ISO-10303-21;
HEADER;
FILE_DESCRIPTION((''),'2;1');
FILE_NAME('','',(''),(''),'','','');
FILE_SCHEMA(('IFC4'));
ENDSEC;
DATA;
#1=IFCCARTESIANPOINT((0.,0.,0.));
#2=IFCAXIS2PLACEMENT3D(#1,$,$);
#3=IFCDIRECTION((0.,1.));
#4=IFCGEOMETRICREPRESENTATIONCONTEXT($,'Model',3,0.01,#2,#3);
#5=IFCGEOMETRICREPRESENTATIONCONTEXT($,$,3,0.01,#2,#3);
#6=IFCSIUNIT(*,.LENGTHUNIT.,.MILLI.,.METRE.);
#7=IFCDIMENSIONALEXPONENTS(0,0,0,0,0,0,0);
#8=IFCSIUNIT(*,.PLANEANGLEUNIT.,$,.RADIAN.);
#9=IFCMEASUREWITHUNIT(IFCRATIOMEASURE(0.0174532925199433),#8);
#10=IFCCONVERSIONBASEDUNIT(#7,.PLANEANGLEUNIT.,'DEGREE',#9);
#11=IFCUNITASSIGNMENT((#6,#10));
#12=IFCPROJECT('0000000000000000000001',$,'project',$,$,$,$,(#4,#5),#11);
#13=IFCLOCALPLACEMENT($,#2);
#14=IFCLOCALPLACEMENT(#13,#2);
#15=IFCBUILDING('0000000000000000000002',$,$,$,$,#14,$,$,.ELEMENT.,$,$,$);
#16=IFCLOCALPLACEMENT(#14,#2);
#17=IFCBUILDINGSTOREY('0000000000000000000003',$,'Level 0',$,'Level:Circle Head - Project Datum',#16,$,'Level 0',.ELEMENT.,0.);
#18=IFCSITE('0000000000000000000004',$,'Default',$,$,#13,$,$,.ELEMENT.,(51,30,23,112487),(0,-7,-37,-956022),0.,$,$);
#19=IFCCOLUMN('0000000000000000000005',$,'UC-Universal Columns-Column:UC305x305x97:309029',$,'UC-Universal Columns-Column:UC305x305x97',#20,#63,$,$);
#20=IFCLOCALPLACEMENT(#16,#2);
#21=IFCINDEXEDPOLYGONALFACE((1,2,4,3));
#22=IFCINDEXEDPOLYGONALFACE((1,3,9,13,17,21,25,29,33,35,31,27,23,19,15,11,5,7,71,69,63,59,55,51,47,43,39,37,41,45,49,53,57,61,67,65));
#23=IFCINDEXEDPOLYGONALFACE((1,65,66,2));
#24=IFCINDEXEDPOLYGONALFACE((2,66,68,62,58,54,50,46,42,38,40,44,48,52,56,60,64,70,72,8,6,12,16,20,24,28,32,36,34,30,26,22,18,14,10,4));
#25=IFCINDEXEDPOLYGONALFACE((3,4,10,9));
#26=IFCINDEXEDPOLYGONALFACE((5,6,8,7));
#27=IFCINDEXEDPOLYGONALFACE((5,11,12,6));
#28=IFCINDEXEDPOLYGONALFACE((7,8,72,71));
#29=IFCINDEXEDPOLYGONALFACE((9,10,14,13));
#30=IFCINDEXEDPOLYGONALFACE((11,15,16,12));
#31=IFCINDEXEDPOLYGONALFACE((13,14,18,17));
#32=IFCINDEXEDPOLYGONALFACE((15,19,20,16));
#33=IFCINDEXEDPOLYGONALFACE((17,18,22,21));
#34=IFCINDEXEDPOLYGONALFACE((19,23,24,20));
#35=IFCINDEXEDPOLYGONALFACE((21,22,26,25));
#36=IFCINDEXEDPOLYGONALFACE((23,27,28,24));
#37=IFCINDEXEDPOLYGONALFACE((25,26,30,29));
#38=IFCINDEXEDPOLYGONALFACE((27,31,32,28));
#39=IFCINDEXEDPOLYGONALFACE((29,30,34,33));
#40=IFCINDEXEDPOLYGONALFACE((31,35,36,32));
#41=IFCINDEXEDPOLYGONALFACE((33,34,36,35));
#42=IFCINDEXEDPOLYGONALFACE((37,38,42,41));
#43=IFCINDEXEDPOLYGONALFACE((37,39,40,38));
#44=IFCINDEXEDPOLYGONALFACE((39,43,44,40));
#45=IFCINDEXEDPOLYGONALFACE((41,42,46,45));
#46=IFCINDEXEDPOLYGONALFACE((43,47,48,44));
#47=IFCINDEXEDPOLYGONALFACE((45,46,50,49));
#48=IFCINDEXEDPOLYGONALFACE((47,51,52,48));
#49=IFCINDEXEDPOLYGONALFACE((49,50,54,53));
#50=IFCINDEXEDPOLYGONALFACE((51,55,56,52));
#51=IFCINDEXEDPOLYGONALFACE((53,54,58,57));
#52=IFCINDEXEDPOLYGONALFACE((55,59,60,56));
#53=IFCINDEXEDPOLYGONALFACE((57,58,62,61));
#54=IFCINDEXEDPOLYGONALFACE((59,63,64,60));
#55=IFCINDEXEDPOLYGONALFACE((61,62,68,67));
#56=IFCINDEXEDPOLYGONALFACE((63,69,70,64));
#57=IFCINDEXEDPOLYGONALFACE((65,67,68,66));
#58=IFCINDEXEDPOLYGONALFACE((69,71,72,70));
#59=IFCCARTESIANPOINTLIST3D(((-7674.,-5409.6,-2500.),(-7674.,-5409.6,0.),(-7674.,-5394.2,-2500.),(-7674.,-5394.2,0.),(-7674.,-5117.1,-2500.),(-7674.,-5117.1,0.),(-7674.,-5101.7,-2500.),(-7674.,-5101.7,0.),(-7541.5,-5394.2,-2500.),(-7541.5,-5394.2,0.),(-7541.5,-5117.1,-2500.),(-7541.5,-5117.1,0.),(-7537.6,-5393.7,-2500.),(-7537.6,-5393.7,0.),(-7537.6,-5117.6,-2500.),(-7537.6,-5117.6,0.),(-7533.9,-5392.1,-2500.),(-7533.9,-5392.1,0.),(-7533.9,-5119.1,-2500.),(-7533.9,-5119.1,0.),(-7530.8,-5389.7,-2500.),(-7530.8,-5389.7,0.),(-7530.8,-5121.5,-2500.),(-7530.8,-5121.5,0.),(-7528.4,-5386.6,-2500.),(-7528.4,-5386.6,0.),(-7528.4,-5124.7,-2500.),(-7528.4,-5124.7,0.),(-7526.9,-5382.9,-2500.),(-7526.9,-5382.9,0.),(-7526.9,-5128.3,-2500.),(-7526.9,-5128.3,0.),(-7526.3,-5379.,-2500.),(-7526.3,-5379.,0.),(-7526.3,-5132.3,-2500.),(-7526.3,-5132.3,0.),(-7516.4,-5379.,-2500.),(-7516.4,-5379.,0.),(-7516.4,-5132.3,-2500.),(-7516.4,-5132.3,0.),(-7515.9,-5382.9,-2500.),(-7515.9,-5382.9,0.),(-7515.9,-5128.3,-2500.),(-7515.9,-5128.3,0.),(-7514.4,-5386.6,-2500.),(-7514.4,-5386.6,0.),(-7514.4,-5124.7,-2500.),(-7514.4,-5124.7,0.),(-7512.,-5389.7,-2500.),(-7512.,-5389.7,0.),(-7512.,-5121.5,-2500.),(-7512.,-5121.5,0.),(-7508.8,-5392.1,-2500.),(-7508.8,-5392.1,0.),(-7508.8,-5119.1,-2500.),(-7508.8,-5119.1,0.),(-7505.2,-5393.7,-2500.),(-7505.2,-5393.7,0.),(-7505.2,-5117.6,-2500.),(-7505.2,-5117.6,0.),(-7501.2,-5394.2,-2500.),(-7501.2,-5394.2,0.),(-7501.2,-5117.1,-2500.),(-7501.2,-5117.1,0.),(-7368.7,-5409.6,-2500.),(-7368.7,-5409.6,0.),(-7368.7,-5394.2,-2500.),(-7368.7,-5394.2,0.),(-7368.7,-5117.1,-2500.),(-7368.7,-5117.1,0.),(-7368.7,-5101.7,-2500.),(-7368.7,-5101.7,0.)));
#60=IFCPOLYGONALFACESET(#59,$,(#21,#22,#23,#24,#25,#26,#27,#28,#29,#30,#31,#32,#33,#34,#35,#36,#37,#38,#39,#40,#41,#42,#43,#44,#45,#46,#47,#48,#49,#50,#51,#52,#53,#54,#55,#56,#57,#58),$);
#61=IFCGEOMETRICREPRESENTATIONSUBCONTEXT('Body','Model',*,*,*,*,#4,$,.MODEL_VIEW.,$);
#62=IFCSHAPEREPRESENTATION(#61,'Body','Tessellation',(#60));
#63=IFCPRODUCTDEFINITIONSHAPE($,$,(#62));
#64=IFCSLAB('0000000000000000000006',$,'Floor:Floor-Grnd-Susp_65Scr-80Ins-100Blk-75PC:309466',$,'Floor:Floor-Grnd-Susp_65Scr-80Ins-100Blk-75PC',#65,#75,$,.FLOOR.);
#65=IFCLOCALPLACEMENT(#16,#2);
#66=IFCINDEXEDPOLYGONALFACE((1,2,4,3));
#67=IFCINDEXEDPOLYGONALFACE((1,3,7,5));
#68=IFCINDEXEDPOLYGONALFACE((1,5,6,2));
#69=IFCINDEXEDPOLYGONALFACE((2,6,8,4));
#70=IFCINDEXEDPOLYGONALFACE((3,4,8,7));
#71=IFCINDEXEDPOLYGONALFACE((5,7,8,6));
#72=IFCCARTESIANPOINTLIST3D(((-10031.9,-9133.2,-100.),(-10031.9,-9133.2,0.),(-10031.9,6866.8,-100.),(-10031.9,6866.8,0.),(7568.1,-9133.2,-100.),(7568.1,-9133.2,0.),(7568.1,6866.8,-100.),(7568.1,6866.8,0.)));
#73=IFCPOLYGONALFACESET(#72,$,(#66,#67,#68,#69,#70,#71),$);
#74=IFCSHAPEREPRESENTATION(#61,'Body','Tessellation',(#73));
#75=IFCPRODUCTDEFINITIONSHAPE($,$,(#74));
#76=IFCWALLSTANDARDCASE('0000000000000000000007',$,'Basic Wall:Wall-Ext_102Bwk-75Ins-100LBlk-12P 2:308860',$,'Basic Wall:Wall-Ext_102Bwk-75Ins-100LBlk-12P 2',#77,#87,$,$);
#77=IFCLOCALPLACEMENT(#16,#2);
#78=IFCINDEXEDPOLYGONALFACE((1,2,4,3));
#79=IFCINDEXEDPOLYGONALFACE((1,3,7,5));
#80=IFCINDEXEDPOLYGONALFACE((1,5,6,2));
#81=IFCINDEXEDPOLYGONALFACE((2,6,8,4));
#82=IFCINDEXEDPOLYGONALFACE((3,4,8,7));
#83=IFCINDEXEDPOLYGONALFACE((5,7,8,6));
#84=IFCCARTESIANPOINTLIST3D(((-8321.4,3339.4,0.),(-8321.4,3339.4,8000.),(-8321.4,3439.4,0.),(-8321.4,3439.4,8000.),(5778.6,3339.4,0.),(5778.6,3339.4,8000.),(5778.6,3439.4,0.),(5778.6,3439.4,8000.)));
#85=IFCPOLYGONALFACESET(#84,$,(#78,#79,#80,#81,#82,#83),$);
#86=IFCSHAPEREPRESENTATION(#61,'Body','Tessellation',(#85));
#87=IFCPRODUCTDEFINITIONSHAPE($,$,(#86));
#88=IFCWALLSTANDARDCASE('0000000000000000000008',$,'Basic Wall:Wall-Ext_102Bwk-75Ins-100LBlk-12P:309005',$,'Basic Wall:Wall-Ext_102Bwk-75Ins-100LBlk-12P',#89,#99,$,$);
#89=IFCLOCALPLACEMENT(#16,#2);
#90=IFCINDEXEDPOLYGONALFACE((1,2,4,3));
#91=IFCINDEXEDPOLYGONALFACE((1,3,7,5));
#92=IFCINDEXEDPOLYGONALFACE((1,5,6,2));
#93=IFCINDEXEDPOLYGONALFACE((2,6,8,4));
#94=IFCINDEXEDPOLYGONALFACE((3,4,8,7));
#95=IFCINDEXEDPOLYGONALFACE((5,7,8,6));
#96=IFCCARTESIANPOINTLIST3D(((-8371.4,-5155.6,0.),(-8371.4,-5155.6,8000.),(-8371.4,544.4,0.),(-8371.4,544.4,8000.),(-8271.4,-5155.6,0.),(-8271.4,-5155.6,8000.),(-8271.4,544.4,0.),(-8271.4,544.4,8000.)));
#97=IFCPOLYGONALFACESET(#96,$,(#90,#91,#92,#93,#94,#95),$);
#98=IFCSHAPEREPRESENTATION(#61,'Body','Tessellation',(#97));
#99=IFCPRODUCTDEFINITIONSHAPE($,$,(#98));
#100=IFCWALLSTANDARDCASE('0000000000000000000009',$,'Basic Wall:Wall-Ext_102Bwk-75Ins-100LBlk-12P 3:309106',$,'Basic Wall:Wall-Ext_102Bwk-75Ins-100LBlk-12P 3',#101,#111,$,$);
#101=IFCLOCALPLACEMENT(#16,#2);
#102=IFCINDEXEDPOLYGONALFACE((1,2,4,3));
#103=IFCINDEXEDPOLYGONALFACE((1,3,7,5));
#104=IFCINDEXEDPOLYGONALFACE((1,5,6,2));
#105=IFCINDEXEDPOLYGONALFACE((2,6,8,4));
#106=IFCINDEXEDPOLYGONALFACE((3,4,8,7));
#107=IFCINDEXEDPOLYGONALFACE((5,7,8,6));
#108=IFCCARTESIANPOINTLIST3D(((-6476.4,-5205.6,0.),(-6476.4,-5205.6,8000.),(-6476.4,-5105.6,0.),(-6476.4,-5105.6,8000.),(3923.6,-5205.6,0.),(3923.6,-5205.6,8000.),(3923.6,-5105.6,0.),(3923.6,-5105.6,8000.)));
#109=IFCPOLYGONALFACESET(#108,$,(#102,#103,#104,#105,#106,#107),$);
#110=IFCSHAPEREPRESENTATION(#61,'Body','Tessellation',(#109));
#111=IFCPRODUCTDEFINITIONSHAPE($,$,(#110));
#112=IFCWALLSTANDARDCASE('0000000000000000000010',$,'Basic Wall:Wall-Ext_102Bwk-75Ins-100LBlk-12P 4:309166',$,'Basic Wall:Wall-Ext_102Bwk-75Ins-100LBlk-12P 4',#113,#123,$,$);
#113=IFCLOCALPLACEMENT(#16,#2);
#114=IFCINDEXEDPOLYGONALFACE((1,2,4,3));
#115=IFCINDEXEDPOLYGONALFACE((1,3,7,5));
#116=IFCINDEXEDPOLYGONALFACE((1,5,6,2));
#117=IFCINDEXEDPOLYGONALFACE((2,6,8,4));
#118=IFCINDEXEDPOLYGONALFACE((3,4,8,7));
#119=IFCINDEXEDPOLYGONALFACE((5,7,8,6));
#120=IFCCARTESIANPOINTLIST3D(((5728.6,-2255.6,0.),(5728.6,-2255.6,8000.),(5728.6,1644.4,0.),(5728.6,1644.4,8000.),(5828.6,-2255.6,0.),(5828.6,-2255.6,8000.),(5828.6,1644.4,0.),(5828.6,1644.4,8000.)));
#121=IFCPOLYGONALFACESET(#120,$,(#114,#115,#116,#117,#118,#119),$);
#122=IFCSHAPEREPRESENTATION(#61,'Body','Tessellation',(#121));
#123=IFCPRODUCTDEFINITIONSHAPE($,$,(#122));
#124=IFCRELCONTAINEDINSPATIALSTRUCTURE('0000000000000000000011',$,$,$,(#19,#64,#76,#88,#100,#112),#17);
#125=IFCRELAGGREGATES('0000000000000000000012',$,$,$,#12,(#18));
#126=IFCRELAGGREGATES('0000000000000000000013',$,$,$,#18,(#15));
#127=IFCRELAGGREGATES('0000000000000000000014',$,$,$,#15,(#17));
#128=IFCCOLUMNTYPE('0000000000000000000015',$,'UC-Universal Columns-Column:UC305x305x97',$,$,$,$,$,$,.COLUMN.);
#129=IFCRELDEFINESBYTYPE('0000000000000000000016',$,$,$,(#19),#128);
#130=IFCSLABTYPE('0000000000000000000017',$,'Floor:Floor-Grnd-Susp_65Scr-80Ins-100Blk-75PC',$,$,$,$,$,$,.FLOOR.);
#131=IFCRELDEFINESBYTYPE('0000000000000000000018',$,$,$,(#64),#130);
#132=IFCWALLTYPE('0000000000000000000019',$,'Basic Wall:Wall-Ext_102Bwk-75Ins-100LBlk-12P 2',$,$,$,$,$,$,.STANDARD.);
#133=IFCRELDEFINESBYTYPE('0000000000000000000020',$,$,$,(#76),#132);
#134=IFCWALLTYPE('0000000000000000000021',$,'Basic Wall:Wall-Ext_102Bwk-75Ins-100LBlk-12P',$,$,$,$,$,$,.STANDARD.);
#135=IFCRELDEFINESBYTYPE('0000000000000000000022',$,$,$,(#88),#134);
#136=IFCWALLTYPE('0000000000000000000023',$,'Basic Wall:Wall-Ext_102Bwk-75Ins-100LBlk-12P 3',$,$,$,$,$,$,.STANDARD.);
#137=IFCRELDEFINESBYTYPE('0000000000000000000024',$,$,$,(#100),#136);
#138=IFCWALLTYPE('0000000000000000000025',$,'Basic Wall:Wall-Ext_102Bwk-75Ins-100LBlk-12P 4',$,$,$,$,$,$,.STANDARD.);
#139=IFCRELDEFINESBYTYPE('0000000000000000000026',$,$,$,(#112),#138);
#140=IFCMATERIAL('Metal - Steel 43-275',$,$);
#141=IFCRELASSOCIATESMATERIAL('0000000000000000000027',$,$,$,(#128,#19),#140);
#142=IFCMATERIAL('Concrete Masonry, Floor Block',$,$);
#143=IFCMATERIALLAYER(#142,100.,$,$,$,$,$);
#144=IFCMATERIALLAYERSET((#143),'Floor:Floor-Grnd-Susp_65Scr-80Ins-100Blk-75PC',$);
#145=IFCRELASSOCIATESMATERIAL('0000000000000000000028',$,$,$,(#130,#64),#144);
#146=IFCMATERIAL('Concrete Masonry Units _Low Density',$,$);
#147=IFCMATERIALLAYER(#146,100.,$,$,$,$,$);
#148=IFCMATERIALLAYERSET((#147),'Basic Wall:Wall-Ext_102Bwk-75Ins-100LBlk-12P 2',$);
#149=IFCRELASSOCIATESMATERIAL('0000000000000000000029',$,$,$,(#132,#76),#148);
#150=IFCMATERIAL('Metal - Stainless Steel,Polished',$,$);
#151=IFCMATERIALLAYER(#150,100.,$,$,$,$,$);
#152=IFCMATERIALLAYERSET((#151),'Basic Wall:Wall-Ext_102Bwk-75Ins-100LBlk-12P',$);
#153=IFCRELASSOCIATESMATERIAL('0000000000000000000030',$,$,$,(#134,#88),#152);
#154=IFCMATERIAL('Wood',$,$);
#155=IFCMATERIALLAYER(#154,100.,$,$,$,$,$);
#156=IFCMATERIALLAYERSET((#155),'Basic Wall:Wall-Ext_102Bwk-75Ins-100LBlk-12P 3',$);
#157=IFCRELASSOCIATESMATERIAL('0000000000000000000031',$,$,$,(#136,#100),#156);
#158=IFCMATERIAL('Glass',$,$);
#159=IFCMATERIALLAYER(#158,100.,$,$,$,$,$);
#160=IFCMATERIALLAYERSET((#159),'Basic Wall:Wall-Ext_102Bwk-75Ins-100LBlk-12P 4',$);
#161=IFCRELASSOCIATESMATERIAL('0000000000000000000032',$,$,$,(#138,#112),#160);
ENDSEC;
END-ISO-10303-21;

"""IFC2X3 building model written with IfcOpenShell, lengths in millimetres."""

from ifc_helpers import new_model, entity, si_unit, converted_unit, direction, frame, frame_2d, origin, origin_2d_with_axis, place, context, subcontext, project, spatial, rectangle, i_section, extrude, source, transform, mapped, material, layer, layer_set, layer_usage, type_object, type_shapes, element, save


model = new_model("IFC2X3")

# Units and contexts
model_context = context("Model", 3, precision=0.01, world=origin(), true_north=direction((0.0, 1.0)))
context_of_model = context(None, 3, precision=0.01, world=origin(), true_north=direction((0.0, 1.0)))
body_context = subcontext(model_context, "Body", "Model", "MODEL_VIEW")
ifc_project = project(units=[si_unit("LENGTHUNIT", "METRE", prefix="MILLI"), converted_unit("PLANEANGLEUNIT", "DEGREE", entity("IfcRatioMeasure", 0.0174532925199433), si_unit("PLANEANGLEUNIT", "RADIAN"), dimensions=[0, 0, 0, 0, 0, 0, 0])], contexts=[model_context, context_of_model])

# Site, building, storey
site_placement = place(None, origin())
site = spatial("IfcSite", under=ifc_project, at=site_placement, Name="Default", CompositionType="ELEMENT", RefLatitude=(51, 30, 23, 112487), RefLongitude=(0, -7, -37, -956022), RefElevation=0.0)
building_placement = place(site_placement, origin())
building = spatial("IfcBuilding", under=site, at=building_placement, CompositionType="ELEMENT")
storey_placement = place(building_placement, origin())
storey = spatial("IfcBuildingStorey", under=building, at=storey_placement, Name="Level 0", ObjectType="Level:Circle Head - Project Datum", LongName="Level 0", CompositionType="ELEMENT", Elevation=0.0)

# Column
ifc_material_1 = material(Name="Metal - Steel 43-275")
column_type = type_object("IfcColumnType", Name="UC-Universal Columns-Column:UC305x305x97", PredefinedType="COLUMN", material=ifc_material_1)
shared_shape = source(origin(), body_context, "Body", "SweptSolid", [
    extrude(i_section(OverallWidth=305.3, OverallDepth=307.9, WebThickness=9.9, FlangeThickness=15.4, FilletRadius=15.2, at=frame_2d((0.0, 0.0), x_axis=(0.0, 1.0))), frame((0.0, 0.0, -2500.0), z_axis=(0.0, 0.0, 1.0), x_axis=(0.0, -1.0, 0.0)), (0.0, 0.0, 1.0), 2500.0),
])
type_shapes(column_type, [shared_shape])
column_placement = place(storey_placement, frame((-7521.4, -5255.6, 0.0)))
element("IfcColumn", 1, at=column_placement, inside=storey, type_object=column_type, material=ifc_material_1, Name="UC-Universal Columns-Column:UC305x305x97:309029", ObjectType="UC-Universal Columns-Column:UC305x305x97", context=body_context, shape_type="MappedRepresentation", body=[
    mapped(shared_shape, transform((0.0, 0.0, 0.0), scale=1.0)),
])

# Slab
ifc_material_2 = material(Name="Concrete Masonry, Floor Block")
ifc_layer_1 = layer(ifc_material_2, 100.0)
ifc_layer_set_1 = layer_set([ifc_layer_1], Name="Floor:Floor-Grnd-Susp_65Scr-80Ins-100Blk-75PC")
ifc_layer_usage_1 = layer_usage(ifc_layer_set_1, "AXIS3", "POSITIVE", 0.0)
slab_type = type_object("IfcSlabType", Name="Floor:Floor-Grnd-Susp_65Scr-80Ins-100Blk-75PC", PredefinedType="FLOOR", material=ifc_layer_set_1)
slab_placement = place(storey_placement, origin())
element("IfcSlab", 2, at=slab_placement, inside=storey, type_object=slab_type, material=ifc_layer_usage_1, Name="Floor:Floor-Grnd-Susp_65Scr-80Ins-100Blk-75PC:309466", ObjectType="Floor:Floor-Grnd-Susp_65Scr-80Ins-100Blk-75PC", PredefinedType="FLOOR", context=body_context, shape_type="SweptSolid", body=[
    extrude(rectangle(XDim=16000.0, YDim=17600.0, at=origin_2d_with_axis()), frame((-1231.9, -1133.2, 0.0), z_axis=(0.0, 0.0, -1.0), x_axis=(0.0, 1.0, 0.0)), (0.0, 0.0, 1.0), 100.0),
])

# Walls
ifc_material_3 = material(Name="Concrete Masonry Units _Low Density")
ifc_layer_2 = layer(ifc_material_3, 100.0)
ifc_layer_set_2 = layer_set([ifc_layer_2], Name="Basic Wall:Wall-Ext_102Bwk-75Ins-100LBlk-12P 2")
ifc_layer_usage_2 = layer_usage(ifc_layer_set_2, "AXIS2", "NEGATIVE", 50.0)
wall_type_1 = type_object("IfcWallType", Name="Basic Wall:Wall-Ext_102Bwk-75Ins-100LBlk-12P 2", PredefinedType="STANDARD", material=ifc_layer_set_2)
wall_1_placement = place(storey_placement, frame((-8321.4, 3389.4, 0.0)))
element("IfcWallStandardCase", 3, at=wall_1_placement, inside=storey, type_object=wall_type_1, material=ifc_layer_usage_2, Name="Basic Wall:Wall-Ext_102Bwk-75Ins-100LBlk-12P 2:308860", ObjectType="Basic Wall:Wall-Ext_102Bwk-75Ins-100LBlk-12P 2", context=body_context, shape_type="SweptSolid", body=[
    extrude(rectangle(XDim=14100.0, YDim=100.0, at=frame_2d((7050.0, 0.0), x_axis=(-1.0, 0.0))), origin(), (0.0, 0.0, 1.0), 8000.0),
])
ifc_material_4 = material(Name="Metal - Stainless Steel,Polished")
ifc_layer_3 = layer(ifc_material_4, 100.0)
ifc_layer_set_3 = layer_set([ifc_layer_3], Name="Basic Wall:Wall-Ext_102Bwk-75Ins-100LBlk-12P")
ifc_layer_usage_3 = layer_usage(ifc_layer_set_3, "AXIS2", "NEGATIVE", 50.0)
wall_type_2 = type_object("IfcWallType", Name="Basic Wall:Wall-Ext_102Bwk-75Ins-100LBlk-12P", PredefinedType="STANDARD", material=ifc_layer_set_3)
wall_2_placement = place(storey_placement, frame((-8321.4, 544.4, 0.0), z_axis=(0.0, 0.0, 1.0), x_axis=(0.0, -1.0, 0.0)))
element("IfcWallStandardCase", 4, at=wall_2_placement, inside=storey, type_object=wall_type_2, material=ifc_layer_usage_3, Name="Basic Wall:Wall-Ext_102Bwk-75Ins-100LBlk-12P:309005", ObjectType="Basic Wall:Wall-Ext_102Bwk-75Ins-100LBlk-12P", context=body_context, shape_type="SweptSolid", body=[
    extrude(rectangle(XDim=5700.0, YDim=100.0, at=frame_2d((2850.0, 0.0), x_axis=(-1.0, 0.0))), origin(), (0.0, 0.0, 1.0), 8000.0),
])
ifc_material_5 = material(Name="Wood")
ifc_layer_4 = layer(ifc_material_5, 100.0)
ifc_layer_set_4 = layer_set([ifc_layer_4], Name="Basic Wall:Wall-Ext_102Bwk-75Ins-100LBlk-12P 3")
ifc_layer_usage_4 = layer_usage(ifc_layer_set_4, "AXIS2", "NEGATIVE", 50.0)
wall_type_3 = type_object("IfcWallType", Name="Basic Wall:Wall-Ext_102Bwk-75Ins-100LBlk-12P 3", PredefinedType="STANDARD", material=ifc_layer_set_4)
wall_3_placement = place(storey_placement, frame((-6476.4, -5155.6, 0.0)))
element("IfcWallStandardCase", 5, at=wall_3_placement, inside=storey, type_object=wall_type_3, material=ifc_layer_usage_4, Name="Basic Wall:Wall-Ext_102Bwk-75Ins-100LBlk-12P 3:309106", ObjectType="Basic Wall:Wall-Ext_102Bwk-75Ins-100LBlk-12P 3", context=body_context, shape_type="SweptSolid", body=[
    extrude(rectangle(XDim=10400.0, YDim=100.0, at=frame_2d((5200.0, 0.0), x_axis=(-1.0, 0.0))), origin(), (0.0, 0.0, 1.0), 8000.0),
])
ifc_material_6 = material(Name="Glass")
ifc_layer_5 = layer(ifc_material_6, 100.0)
ifc_layer_set_5 = layer_set([ifc_layer_5], Name="Basic Wall:Wall-Ext_102Bwk-75Ins-100LBlk-12P 4")
ifc_layer_usage_5 = layer_usage(ifc_layer_set_5, "AXIS2", "NEGATIVE", 50.0)
wall_type_4 = type_object("IfcWallType", Name="Basic Wall:Wall-Ext_102Bwk-75Ins-100LBlk-12P 4", PredefinedType="STANDARD", material=ifc_layer_set_5)
wall_4_placement = place(storey_placement, frame((5778.6, 1644.4, 0.0), z_axis=(0.0, 0.0, 1.0), x_axis=(0.0, -1.0, 0.0)))
element("IfcWallStandardCase", 6, at=wall_4_placement, inside=storey, type_object=wall_type_4, material=ifc_layer_usage_5, Name="Basic Wall:Wall-Ext_102Bwk-75Ins-100LBlk-12P 4:309166", ObjectType="Basic Wall:Wall-Ext_102Bwk-75Ins-100LBlk-12P 4", context=body_context, shape_type="SweptSolid", body=[
    extrude(rectangle(XDim=3900.0, YDim=100.0, at=frame_2d((1950.0, 0.0), x_axis=(-1.0, 0.0))), origin(), (0.0, 0.0, 1.0), 8000.0),
])

save(model, "model.ifc")
